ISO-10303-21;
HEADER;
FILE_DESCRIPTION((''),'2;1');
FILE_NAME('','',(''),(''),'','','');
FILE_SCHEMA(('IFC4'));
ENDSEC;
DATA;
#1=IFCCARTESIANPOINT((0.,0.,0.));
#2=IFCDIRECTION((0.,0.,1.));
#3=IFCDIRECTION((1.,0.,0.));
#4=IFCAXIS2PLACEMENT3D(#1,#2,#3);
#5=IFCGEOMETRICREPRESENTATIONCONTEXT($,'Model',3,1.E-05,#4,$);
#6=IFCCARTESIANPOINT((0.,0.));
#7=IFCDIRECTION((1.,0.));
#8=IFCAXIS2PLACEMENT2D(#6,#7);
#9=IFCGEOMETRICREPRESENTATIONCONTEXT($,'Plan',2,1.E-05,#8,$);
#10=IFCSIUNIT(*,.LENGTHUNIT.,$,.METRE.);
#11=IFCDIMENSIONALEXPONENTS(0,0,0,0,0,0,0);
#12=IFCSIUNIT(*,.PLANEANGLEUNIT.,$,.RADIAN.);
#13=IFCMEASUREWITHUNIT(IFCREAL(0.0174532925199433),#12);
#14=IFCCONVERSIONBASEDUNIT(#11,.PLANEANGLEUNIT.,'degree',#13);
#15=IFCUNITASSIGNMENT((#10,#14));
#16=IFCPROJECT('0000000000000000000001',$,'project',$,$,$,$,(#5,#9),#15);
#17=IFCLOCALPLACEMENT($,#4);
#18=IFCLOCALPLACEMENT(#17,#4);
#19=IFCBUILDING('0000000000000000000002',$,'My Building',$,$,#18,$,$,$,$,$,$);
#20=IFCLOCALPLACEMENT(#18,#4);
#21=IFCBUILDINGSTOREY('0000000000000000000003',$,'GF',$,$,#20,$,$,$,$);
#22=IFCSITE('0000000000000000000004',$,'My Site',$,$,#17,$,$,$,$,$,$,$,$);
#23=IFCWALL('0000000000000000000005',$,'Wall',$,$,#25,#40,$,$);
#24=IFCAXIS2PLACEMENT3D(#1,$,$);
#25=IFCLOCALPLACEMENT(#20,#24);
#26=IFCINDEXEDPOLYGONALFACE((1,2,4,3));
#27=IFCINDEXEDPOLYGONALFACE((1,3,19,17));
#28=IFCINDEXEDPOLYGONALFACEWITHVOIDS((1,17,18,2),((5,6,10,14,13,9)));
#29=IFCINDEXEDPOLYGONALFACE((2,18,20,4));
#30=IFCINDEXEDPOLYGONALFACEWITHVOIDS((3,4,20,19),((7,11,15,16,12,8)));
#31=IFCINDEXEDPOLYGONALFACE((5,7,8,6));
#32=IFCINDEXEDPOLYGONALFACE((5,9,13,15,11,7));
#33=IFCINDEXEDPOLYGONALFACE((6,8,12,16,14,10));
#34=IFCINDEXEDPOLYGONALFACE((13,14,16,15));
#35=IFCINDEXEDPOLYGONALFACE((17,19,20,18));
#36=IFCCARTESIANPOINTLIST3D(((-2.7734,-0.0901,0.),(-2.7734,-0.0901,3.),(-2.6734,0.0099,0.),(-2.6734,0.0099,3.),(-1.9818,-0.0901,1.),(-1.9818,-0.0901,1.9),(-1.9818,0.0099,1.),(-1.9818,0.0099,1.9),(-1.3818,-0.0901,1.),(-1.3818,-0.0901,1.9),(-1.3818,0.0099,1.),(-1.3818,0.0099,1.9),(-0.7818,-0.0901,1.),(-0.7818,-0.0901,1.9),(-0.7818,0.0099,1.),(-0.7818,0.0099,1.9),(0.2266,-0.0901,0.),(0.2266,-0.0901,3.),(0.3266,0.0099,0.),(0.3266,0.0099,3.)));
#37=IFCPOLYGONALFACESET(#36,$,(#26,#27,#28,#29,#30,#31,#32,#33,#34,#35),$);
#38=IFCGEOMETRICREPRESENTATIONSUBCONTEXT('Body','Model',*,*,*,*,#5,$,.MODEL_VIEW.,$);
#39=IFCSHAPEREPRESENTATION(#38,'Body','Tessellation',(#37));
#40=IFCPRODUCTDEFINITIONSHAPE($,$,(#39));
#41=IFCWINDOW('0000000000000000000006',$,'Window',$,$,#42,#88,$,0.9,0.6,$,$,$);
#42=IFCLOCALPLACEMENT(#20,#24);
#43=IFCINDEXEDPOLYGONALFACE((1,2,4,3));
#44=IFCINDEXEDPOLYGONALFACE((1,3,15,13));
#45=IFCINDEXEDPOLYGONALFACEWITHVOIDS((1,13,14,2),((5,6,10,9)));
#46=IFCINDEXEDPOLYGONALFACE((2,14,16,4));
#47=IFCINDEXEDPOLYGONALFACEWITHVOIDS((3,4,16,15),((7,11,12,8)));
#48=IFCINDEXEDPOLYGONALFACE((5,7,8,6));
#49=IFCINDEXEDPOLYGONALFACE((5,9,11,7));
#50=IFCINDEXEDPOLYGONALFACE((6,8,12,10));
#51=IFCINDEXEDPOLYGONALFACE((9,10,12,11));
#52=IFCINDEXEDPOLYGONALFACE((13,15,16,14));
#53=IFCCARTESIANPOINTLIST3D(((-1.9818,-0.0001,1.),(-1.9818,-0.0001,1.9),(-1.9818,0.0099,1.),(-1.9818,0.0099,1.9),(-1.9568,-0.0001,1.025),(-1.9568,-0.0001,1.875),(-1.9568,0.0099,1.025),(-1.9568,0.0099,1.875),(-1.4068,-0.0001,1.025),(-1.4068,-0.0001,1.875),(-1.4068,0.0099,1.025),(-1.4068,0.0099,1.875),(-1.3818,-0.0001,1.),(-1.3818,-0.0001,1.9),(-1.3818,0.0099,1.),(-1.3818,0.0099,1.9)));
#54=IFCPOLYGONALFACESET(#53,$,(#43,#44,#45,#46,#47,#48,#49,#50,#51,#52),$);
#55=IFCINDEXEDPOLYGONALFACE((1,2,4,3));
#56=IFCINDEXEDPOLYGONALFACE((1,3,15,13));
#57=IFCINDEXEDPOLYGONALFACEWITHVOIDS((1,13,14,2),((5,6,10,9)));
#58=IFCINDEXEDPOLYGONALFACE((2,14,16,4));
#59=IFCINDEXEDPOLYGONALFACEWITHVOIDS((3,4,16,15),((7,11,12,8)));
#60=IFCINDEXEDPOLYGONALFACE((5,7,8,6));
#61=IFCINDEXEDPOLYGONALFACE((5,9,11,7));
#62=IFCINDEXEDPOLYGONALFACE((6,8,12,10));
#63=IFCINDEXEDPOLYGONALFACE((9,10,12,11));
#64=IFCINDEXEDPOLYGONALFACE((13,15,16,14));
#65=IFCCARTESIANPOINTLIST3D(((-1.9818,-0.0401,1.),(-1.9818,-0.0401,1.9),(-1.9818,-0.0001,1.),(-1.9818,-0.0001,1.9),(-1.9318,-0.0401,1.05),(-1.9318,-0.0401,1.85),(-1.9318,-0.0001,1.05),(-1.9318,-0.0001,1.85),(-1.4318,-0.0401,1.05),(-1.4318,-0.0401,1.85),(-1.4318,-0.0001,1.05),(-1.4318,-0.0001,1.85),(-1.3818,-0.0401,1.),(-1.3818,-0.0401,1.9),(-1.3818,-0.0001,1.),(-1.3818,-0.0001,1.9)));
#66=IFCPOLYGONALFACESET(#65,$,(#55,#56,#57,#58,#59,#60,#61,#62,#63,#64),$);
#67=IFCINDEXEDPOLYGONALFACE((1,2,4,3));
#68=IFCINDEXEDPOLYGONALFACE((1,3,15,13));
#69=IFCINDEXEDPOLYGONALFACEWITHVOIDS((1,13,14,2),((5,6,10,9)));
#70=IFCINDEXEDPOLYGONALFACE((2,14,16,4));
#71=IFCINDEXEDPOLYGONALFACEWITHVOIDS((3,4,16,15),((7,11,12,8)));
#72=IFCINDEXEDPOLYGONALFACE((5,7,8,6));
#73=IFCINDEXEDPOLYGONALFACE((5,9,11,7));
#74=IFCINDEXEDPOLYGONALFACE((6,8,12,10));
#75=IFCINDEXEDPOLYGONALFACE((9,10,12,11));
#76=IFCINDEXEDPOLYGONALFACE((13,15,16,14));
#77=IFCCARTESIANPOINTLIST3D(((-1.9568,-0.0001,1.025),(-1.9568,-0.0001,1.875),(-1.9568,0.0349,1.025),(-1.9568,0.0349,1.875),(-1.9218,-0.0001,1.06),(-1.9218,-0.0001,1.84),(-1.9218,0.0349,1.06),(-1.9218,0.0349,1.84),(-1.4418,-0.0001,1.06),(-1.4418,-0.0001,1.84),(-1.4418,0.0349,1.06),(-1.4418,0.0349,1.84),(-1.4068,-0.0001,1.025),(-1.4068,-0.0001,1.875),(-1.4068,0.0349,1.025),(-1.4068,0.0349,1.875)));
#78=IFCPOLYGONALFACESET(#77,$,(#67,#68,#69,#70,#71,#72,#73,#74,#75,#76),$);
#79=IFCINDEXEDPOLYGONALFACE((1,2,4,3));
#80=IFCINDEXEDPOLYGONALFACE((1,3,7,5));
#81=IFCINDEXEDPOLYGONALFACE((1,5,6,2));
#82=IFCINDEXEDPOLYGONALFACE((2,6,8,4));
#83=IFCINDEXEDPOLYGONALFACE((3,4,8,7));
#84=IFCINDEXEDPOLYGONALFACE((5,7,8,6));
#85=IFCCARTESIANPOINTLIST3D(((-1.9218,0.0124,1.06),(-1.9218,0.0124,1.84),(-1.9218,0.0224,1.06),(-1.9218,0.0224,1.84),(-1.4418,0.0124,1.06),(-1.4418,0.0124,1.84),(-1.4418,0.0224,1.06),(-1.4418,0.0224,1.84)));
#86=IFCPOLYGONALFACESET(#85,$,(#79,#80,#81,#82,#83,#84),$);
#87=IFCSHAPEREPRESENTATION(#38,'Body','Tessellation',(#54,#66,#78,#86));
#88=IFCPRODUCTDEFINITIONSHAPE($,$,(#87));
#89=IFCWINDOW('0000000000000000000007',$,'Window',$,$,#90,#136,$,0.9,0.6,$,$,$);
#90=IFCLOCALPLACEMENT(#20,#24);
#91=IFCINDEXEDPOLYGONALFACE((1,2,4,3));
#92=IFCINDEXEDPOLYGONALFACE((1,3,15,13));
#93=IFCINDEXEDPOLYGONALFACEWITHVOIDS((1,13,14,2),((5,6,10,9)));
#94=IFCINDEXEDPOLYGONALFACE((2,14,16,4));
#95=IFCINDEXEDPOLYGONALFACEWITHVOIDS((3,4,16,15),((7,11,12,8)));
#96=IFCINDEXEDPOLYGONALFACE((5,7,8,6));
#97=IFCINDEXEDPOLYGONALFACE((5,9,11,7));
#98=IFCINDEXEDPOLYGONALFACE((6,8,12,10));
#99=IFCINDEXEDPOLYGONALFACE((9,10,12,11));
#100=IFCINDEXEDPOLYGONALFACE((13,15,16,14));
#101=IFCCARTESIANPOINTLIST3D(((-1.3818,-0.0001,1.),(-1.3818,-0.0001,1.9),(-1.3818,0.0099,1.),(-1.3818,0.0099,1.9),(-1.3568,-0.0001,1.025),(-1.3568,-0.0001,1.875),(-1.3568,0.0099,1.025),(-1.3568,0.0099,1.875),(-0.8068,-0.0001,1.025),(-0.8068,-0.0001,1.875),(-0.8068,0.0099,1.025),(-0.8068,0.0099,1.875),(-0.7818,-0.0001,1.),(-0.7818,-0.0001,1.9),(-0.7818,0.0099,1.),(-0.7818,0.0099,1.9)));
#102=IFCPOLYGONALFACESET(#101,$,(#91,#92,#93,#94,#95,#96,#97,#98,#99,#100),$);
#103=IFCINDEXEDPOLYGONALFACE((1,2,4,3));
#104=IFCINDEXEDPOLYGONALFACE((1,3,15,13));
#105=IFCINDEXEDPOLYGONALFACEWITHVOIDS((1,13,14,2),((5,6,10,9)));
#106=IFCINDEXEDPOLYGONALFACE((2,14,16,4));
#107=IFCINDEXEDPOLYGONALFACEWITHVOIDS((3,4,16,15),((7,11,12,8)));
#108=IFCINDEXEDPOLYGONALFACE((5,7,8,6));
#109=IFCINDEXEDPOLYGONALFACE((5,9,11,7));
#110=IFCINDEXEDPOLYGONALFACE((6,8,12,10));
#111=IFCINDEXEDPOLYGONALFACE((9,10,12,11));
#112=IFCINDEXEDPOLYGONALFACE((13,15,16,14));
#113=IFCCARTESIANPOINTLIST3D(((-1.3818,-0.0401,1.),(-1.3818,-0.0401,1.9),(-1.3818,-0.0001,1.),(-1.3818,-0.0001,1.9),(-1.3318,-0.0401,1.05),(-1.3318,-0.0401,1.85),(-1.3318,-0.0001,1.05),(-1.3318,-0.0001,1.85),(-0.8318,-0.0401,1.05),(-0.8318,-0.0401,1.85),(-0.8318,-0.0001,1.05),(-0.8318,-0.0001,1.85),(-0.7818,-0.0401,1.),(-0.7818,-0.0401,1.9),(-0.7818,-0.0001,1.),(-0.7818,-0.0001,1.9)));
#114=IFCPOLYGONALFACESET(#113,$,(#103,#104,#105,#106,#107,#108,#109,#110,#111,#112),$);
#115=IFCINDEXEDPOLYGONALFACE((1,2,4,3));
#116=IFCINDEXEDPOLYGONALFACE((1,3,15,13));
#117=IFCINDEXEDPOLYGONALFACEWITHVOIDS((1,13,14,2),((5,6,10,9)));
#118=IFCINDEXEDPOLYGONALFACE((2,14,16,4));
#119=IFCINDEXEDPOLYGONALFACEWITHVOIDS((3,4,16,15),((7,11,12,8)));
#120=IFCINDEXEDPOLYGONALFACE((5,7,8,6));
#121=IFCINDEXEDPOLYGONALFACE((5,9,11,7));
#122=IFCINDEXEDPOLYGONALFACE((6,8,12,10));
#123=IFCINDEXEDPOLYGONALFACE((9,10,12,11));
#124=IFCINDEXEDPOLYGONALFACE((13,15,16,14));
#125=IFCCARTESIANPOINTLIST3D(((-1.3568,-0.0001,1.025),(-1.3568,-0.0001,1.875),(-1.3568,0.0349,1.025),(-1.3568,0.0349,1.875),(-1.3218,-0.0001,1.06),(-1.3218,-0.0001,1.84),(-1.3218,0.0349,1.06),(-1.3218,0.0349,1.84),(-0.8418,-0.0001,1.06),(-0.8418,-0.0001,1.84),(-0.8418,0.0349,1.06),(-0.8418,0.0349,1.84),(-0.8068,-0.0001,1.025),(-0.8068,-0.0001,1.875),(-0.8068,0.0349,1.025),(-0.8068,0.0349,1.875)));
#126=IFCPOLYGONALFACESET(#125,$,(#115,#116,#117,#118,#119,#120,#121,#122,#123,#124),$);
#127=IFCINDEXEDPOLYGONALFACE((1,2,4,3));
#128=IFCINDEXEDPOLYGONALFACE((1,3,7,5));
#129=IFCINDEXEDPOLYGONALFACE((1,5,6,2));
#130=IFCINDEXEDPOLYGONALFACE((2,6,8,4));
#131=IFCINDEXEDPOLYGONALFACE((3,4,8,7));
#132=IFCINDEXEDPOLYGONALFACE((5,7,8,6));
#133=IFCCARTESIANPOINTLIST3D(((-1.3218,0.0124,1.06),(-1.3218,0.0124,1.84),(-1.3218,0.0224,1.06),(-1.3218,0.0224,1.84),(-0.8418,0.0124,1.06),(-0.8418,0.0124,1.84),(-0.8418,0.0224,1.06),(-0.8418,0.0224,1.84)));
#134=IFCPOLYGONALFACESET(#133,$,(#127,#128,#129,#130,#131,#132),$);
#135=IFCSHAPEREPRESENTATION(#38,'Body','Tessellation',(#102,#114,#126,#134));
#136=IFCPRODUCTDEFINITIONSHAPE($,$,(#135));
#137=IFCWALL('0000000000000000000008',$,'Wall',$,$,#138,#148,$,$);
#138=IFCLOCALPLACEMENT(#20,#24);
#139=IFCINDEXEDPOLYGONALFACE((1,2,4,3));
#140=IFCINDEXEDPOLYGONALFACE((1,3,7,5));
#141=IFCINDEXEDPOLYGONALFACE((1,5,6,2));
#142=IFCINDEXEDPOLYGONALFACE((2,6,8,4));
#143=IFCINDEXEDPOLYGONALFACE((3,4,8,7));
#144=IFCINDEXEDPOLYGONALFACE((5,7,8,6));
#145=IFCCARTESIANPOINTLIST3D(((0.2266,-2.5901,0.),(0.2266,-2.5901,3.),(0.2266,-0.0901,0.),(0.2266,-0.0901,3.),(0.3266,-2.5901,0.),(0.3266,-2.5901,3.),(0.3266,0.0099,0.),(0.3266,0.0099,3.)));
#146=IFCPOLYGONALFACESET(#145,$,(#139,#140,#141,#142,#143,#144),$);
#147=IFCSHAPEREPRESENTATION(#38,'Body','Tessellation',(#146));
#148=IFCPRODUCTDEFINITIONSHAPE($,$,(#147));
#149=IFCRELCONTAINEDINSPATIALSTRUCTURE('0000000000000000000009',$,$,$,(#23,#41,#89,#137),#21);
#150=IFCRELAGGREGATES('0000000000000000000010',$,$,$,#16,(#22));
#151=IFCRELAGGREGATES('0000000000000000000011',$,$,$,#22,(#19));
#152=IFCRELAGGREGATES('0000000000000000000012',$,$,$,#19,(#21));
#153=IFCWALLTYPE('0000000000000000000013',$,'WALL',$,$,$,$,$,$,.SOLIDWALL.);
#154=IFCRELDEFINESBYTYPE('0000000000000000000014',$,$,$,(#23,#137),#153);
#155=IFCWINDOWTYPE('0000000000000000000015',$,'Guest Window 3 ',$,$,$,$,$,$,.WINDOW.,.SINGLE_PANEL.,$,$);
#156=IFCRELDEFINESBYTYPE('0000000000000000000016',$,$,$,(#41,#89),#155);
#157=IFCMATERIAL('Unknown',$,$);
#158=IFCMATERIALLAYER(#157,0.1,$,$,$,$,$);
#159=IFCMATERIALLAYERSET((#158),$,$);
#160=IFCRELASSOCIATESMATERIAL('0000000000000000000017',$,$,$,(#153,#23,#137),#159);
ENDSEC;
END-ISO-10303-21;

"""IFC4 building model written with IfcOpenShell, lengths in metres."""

from ifc_helpers import new_model, entity, si_unit, converted_unit, frame, origin_with_axes, origin_2d_with_axis, place, context, subcontext, project, spatial, line, indexed_curve, outline, extrude, shape, source, transform, mapped, material, layer, layer_set, layer_usage, type_object, type_shapes, element, fill, save


model = new_model("IFC4")

# Units and contexts
model_context = context("Model", 3, precision=1e-05, world=origin_with_axes())
plan_context = context("Plan", 2, precision=1e-05, world=origin_2d_with_axis())
body_context_1 = subcontext(model_context, "Body", "Model", "MODEL_VIEW")
body_context_2 = subcontext(plan_context, "Body", "Plan", "PLAN_VIEW")
ifc_project = project(units=[si_unit("LENGTHUNIT", "METRE"), converted_unit("PLANEANGLEUNIT", "degree", entity("IfcReal", 0.0174532925199433), si_unit("PLANEANGLEUNIT", "RADIAN"), dimensions=[0, 0, 0, 0, 0, 0, 0])], contexts=[model_context, plan_context])

# Site, building, storey
site_placement = place(None, origin_with_axes())
site = spatial("IfcSite", under=ifc_project, at=site_placement, Name="My Site")
building_placement = place(site_placement, origin_with_axes())
building = spatial("IfcBuilding", under=site, at=building_placement, Name="My Building")
storey_placement = place(building_placement, origin_with_axes())
storey = spatial("IfcBuildingStorey", under=building, at=storey_placement, Name="GF")

# Shared definitions
ifc_material_1 = material(Name="Unknown")

# Shared definitions
ifc_layer_1 = layer(ifc_material_1, 0.1)
ifc_layer_set_1 = layer_set([ifc_layer_1])
wall_type = type_object("IfcWallType", Name="WALL", PredefinedType="SOLIDWALL", material=ifc_layer_set_1)

# Shared definitions
shared_shape_1 = source(origin_with_axes(), body_context_1, "Body", "SweptSolid", [
    extrude(outline(indexed_curve([(0.0, 0.0), (0.6, 0.0), (0.6, 0.9), (0.0, 0.9)], segments=[line(1, 2, 3, 4, 1)])), frame((0.0, -0.6, 0.0), z_axis=(0.0, -1.0, 0.0), x_axis=(1.0, 0.0, 0.0)), (0.0, 0.0, -1.0), 1.2),
])
window_type_1 = type_object("IfcWindowType", Name="Guest Window 3 ", PartitioningType="SINGLE_PANEL", PredefinedType="WINDOW")
shared_shape_2 = source(origin_with_axes(), body_context_1, "Body", "SweptSolid", [
    extrude(outline(indexed_curve([(0.0, 0.0), (0.6, 0.0), (0.6, 0.9), (0.0, 0.9)], segments=[line(1, 2, 3, 4, 1)]), holes=[indexed_curve([(0.025, 0.025), (0.575, 0.025), (0.575, 0.875), (0.025, 0.875)], segments=[line(1, 2, 3, 4, 1)])]), frame((0.0, 0.09, 0.0), z_axis=(0.0, -1.0, 0.0), x_axis=(1.0, 0.0, 0.0)), (0.0, 0.0, -1.0), 0.01),
    extrude(outline(indexed_curve([(0.0, 0.0), (0.6, 0.0), (0.6, 0.9), (0.0, 0.9)], segments=[line(1, 2, 3, 4, 1)]), holes=[indexed_curve([(0.05, 0.05), (0.55, 0.05), (0.55, 0.85), (0.05, 0.85)], segments=[line(1, 2, 3, 4, 1)])]), frame((0.0, 0.05, 0.0), z_axis=(0.0, -1.0, 0.0), x_axis=(1.0, 0.0, 0.0)), (0.0, 0.0, -1.0), 0.04),
    extrude(outline(indexed_curve([(0.0, 0.0), (0.55, 0.0), (0.55, 0.85), (0.0, 0.85)], segments=[line(1, 2, 3, 4, 1)]), holes=[indexed_curve([(0.035, 0.035), (0.515, 0.035), (0.515, 0.815), (0.035, 0.815)], segments=[line(1, 2, 3, 4, 1)])]), frame((0.025, 0.09, 0.025), z_axis=(0.0, -1.0, 0.0), x_axis=(1.0, 0.0, 0.0)), (0.0, 0.0, -1.0), 0.035),
    extrude(outline(indexed_curve([(0.035, 0.035), (0.515, 0.035), (0.515, 0.815), (0.035, 0.815)], segments=[line(1, 2, 3, 4, 1)])), frame((0.025, 0.1025, 0.025), z_axis=(0.0, -1.0, 0.0), x_axis=(1.0, 0.0, 0.0)), (0.0, 0.0, -1.0), 0.01),
])
shared_shape_3 = source(origin_with_axes(), body_context_2, "Body", "Curve2D", [
    entity("IfcIndexedPolyCurve", entity("IfcCartesianPointList2D", [[0.05, 0.05], [0.55, 0.05]])),
    entity("IfcIndexedPolyCurve", entity("IfcCartesianPointList2D", [[0.0, 0.1], [0.025, 0.1], [0.025, 0.09], [0.05, 0.09], [0.05, 0.05], [0.0, 0.05]]), [entity("IfcLineIndex", [1, 2, 3, 4, 5, 6, 1])]),
    entity("IfcIndexedPolyCurve", entity("IfcCartesianPointList2D", [[0.6, 0.1], [0.575, 0.1], [0.575, 0.09], [0.55, 0.09], [0.55, 0.05], [0.6, 0.05]]), [entity("IfcLineIndex", [1, 2, 3, 4, 5, 6, 1])]),
    entity("IfcIndexedPolyCurve", entity("IfcCartesianPointList2D", [[0.025, 0.09], [0.06, 0.09], [0.06, 0.125], [0.025, 0.125]]), [entity("IfcLineIndex", [1, 2, 3, 4, 1])]),
    entity("IfcIndexedPolyCurve", entity("IfcCartesianPointList2D", [[0.575, 0.09], [0.54, 0.09], [0.54, 0.125], [0.575, 0.125]]), [entity("IfcLineIndex", [1, 2, 3, 4, 1])]),
    entity("IfcIndexedPolyCurve", entity("IfcCartesianPointList2D", [[0.06, 0.09], [0.54, 0.09]])),
    entity("IfcIndexedPolyCurve", entity("IfcCartesianPointList2D", [[0.06, 0.125], [0.54, 0.125]])),
    entity("IfcIndexedPolyCurve", entity("IfcCartesianPointList2D", [[0.06, 0.1075], [0.54, 0.1075]])),
])
type_shapes(window_type_1, [shared_shape_2, shared_shape_3])

# Wall, openings, windows
ifc_layer_usage_1 = layer_usage(ifc_layer_set_1, "AXIS2", "POSITIVE", 0.0)
wall_1_placement = place(storey_placement, frame((-2.7734, -0.0901, 0.0), z_axis=(0.0, 0.0, 1.0), x_axis=(1.0, 0.0, 0.0)))
wall_1 = element("IfcWall", 1, at=wall_1_placement, inside=storey, type_object=wall_type, material=ifc_layer_usage_1, Name="Wall", context=body_context_1, shape_type="SweptSolid", body=[
    extrude(outline(indexed_curve([(0.0, 0.0), (0.1, 0.1), (3.1, 0.1), (3.0, 0.0)], segments=[line(1, 2, 3, 4, 1)])), origin_with_axes(), (0.0, 0.0, 1.0), 3.0),
])
opening_1_placement = place(wall_1_placement, frame((0.7916, 0.0, 1.0), z_axis=(0.0, 0.0, 1.0), x_axis=(1.0, 0.0, 0.0)))
opening_1 = element("IfcOpeningElement", 2, at=opening_1_placement, cuts=wall_1, PredefinedType="OPENING", context=body_context_1, shape_type="MappedRepresentation", body=[
    mapped(shared_shape_1, transform((0.0, 0.0, 0.0), x_axis=(1.0, 0.0, 0.0), y_axis=(0.0, 1.0, 0.0), z_axis=(0.0, 0.0, 1.0), scale=1.0)),
])
opening_2_placement = place(wall_1_placement, frame((1.3916, 0.0, 1.0), z_axis=(0.0, 0.0, 1.0), x_axis=(1.0, 0.0, 0.0)))
opening_2 = element("IfcOpeningElement", 3, at=opening_2_placement, cuts=wall_1, PredefinedType="OPENING", context=body_context_1, shape_type="MappedRepresentation", body=[
    mapped(shared_shape_1, transform((0.0, 0.0, 0.0), x_axis=(1.0, 0.0, 0.0), y_axis=(0.0, 1.0, 0.0), z_axis=(0.0, 0.0, 1.0), scale=1.0)),
])
window_1_placement = place(opening_1_placement, origin_with_axes())
window_1 = element("IfcWindow", 4, at=window_1_placement, inside=storey, type_object=window_type_1, Name="Window", OverallHeight=0.9, OverallWidth=0.6, shapes=[
    shape(body_context_1, "Body", "MappedRepresentation", [mapped(shared_shape_2, transform((0.0, 0.0, 0.0), x_axis=(1.0, 0.0, 0.0), y_axis=(0.0, 1.0, 0.0), z_axis=(0.0, 0.0, 1.0), scale=1.0))]),
    shape(body_context_2, "Body", "MappedRepresentation", [mapped(shared_shape_3, transform((0.0, 0.0, 0.0), x_axis=(1.0, 0.0, 0.0), y_axis=(0.0, 1.0, 0.0), z_axis=(0.0, 0.0, 1.0), scale=1.0))]),
])
fill(opening_1, window_1)
window_2_placement = place(opening_2_placement, origin_with_axes())
window_2 = element("IfcWindow", 5, at=window_2_placement, inside=storey, type_object=window_type_1, Name="Window", OverallHeight=0.9, OverallWidth=0.6, shapes=[
    shape(body_context_1, "Body", "MappedRepresentation", [mapped(shared_shape_2, transform((0.0, 0.0, 0.0), x_axis=(1.0, 0.0, 0.0), y_axis=(0.0, 1.0, 0.0), z_axis=(0.0, 0.0, 1.0), scale=1.0))]),
    shape(body_context_2, "Body", "MappedRepresentation", [mapped(shared_shape_3, transform((0.0, 0.0, 0.0), x_axis=(1.0, 0.0, 0.0), y_axis=(0.0, 1.0, 0.0), z_axis=(0.0, 0.0, 1.0), scale=1.0))]),
])
fill(opening_2, window_2)

# Wall
ifc_layer_usage_2 = layer_usage(ifc_layer_set_1, "AXIS2", "POSITIVE", 0.0)
wall_2_placement = place(storey_placement, frame((0.2266, -0.0901, 0.0), z_axis=(0.0, 0.0, 1.0), x_axis=(0.0, -1.0, 0.0)))
element("IfcWall", 6, at=wall_2_placement, inside=storey, type_object=wall_type, material=ifc_layer_usage_2, Name="Wall", context=body_context_1, shape_type="SweptSolid", body=[
    extrude(outline(indexed_curve([(0.0, 0.0), (-0.1, 0.1), (2.5, 0.1), (2.5, 0.0)], segments=[line(1, 2, 3, 4, 1)])), origin_with_axes(), (0.0, 0.0, 1.0), 3.0),
])

save(model, "model.ifc")
